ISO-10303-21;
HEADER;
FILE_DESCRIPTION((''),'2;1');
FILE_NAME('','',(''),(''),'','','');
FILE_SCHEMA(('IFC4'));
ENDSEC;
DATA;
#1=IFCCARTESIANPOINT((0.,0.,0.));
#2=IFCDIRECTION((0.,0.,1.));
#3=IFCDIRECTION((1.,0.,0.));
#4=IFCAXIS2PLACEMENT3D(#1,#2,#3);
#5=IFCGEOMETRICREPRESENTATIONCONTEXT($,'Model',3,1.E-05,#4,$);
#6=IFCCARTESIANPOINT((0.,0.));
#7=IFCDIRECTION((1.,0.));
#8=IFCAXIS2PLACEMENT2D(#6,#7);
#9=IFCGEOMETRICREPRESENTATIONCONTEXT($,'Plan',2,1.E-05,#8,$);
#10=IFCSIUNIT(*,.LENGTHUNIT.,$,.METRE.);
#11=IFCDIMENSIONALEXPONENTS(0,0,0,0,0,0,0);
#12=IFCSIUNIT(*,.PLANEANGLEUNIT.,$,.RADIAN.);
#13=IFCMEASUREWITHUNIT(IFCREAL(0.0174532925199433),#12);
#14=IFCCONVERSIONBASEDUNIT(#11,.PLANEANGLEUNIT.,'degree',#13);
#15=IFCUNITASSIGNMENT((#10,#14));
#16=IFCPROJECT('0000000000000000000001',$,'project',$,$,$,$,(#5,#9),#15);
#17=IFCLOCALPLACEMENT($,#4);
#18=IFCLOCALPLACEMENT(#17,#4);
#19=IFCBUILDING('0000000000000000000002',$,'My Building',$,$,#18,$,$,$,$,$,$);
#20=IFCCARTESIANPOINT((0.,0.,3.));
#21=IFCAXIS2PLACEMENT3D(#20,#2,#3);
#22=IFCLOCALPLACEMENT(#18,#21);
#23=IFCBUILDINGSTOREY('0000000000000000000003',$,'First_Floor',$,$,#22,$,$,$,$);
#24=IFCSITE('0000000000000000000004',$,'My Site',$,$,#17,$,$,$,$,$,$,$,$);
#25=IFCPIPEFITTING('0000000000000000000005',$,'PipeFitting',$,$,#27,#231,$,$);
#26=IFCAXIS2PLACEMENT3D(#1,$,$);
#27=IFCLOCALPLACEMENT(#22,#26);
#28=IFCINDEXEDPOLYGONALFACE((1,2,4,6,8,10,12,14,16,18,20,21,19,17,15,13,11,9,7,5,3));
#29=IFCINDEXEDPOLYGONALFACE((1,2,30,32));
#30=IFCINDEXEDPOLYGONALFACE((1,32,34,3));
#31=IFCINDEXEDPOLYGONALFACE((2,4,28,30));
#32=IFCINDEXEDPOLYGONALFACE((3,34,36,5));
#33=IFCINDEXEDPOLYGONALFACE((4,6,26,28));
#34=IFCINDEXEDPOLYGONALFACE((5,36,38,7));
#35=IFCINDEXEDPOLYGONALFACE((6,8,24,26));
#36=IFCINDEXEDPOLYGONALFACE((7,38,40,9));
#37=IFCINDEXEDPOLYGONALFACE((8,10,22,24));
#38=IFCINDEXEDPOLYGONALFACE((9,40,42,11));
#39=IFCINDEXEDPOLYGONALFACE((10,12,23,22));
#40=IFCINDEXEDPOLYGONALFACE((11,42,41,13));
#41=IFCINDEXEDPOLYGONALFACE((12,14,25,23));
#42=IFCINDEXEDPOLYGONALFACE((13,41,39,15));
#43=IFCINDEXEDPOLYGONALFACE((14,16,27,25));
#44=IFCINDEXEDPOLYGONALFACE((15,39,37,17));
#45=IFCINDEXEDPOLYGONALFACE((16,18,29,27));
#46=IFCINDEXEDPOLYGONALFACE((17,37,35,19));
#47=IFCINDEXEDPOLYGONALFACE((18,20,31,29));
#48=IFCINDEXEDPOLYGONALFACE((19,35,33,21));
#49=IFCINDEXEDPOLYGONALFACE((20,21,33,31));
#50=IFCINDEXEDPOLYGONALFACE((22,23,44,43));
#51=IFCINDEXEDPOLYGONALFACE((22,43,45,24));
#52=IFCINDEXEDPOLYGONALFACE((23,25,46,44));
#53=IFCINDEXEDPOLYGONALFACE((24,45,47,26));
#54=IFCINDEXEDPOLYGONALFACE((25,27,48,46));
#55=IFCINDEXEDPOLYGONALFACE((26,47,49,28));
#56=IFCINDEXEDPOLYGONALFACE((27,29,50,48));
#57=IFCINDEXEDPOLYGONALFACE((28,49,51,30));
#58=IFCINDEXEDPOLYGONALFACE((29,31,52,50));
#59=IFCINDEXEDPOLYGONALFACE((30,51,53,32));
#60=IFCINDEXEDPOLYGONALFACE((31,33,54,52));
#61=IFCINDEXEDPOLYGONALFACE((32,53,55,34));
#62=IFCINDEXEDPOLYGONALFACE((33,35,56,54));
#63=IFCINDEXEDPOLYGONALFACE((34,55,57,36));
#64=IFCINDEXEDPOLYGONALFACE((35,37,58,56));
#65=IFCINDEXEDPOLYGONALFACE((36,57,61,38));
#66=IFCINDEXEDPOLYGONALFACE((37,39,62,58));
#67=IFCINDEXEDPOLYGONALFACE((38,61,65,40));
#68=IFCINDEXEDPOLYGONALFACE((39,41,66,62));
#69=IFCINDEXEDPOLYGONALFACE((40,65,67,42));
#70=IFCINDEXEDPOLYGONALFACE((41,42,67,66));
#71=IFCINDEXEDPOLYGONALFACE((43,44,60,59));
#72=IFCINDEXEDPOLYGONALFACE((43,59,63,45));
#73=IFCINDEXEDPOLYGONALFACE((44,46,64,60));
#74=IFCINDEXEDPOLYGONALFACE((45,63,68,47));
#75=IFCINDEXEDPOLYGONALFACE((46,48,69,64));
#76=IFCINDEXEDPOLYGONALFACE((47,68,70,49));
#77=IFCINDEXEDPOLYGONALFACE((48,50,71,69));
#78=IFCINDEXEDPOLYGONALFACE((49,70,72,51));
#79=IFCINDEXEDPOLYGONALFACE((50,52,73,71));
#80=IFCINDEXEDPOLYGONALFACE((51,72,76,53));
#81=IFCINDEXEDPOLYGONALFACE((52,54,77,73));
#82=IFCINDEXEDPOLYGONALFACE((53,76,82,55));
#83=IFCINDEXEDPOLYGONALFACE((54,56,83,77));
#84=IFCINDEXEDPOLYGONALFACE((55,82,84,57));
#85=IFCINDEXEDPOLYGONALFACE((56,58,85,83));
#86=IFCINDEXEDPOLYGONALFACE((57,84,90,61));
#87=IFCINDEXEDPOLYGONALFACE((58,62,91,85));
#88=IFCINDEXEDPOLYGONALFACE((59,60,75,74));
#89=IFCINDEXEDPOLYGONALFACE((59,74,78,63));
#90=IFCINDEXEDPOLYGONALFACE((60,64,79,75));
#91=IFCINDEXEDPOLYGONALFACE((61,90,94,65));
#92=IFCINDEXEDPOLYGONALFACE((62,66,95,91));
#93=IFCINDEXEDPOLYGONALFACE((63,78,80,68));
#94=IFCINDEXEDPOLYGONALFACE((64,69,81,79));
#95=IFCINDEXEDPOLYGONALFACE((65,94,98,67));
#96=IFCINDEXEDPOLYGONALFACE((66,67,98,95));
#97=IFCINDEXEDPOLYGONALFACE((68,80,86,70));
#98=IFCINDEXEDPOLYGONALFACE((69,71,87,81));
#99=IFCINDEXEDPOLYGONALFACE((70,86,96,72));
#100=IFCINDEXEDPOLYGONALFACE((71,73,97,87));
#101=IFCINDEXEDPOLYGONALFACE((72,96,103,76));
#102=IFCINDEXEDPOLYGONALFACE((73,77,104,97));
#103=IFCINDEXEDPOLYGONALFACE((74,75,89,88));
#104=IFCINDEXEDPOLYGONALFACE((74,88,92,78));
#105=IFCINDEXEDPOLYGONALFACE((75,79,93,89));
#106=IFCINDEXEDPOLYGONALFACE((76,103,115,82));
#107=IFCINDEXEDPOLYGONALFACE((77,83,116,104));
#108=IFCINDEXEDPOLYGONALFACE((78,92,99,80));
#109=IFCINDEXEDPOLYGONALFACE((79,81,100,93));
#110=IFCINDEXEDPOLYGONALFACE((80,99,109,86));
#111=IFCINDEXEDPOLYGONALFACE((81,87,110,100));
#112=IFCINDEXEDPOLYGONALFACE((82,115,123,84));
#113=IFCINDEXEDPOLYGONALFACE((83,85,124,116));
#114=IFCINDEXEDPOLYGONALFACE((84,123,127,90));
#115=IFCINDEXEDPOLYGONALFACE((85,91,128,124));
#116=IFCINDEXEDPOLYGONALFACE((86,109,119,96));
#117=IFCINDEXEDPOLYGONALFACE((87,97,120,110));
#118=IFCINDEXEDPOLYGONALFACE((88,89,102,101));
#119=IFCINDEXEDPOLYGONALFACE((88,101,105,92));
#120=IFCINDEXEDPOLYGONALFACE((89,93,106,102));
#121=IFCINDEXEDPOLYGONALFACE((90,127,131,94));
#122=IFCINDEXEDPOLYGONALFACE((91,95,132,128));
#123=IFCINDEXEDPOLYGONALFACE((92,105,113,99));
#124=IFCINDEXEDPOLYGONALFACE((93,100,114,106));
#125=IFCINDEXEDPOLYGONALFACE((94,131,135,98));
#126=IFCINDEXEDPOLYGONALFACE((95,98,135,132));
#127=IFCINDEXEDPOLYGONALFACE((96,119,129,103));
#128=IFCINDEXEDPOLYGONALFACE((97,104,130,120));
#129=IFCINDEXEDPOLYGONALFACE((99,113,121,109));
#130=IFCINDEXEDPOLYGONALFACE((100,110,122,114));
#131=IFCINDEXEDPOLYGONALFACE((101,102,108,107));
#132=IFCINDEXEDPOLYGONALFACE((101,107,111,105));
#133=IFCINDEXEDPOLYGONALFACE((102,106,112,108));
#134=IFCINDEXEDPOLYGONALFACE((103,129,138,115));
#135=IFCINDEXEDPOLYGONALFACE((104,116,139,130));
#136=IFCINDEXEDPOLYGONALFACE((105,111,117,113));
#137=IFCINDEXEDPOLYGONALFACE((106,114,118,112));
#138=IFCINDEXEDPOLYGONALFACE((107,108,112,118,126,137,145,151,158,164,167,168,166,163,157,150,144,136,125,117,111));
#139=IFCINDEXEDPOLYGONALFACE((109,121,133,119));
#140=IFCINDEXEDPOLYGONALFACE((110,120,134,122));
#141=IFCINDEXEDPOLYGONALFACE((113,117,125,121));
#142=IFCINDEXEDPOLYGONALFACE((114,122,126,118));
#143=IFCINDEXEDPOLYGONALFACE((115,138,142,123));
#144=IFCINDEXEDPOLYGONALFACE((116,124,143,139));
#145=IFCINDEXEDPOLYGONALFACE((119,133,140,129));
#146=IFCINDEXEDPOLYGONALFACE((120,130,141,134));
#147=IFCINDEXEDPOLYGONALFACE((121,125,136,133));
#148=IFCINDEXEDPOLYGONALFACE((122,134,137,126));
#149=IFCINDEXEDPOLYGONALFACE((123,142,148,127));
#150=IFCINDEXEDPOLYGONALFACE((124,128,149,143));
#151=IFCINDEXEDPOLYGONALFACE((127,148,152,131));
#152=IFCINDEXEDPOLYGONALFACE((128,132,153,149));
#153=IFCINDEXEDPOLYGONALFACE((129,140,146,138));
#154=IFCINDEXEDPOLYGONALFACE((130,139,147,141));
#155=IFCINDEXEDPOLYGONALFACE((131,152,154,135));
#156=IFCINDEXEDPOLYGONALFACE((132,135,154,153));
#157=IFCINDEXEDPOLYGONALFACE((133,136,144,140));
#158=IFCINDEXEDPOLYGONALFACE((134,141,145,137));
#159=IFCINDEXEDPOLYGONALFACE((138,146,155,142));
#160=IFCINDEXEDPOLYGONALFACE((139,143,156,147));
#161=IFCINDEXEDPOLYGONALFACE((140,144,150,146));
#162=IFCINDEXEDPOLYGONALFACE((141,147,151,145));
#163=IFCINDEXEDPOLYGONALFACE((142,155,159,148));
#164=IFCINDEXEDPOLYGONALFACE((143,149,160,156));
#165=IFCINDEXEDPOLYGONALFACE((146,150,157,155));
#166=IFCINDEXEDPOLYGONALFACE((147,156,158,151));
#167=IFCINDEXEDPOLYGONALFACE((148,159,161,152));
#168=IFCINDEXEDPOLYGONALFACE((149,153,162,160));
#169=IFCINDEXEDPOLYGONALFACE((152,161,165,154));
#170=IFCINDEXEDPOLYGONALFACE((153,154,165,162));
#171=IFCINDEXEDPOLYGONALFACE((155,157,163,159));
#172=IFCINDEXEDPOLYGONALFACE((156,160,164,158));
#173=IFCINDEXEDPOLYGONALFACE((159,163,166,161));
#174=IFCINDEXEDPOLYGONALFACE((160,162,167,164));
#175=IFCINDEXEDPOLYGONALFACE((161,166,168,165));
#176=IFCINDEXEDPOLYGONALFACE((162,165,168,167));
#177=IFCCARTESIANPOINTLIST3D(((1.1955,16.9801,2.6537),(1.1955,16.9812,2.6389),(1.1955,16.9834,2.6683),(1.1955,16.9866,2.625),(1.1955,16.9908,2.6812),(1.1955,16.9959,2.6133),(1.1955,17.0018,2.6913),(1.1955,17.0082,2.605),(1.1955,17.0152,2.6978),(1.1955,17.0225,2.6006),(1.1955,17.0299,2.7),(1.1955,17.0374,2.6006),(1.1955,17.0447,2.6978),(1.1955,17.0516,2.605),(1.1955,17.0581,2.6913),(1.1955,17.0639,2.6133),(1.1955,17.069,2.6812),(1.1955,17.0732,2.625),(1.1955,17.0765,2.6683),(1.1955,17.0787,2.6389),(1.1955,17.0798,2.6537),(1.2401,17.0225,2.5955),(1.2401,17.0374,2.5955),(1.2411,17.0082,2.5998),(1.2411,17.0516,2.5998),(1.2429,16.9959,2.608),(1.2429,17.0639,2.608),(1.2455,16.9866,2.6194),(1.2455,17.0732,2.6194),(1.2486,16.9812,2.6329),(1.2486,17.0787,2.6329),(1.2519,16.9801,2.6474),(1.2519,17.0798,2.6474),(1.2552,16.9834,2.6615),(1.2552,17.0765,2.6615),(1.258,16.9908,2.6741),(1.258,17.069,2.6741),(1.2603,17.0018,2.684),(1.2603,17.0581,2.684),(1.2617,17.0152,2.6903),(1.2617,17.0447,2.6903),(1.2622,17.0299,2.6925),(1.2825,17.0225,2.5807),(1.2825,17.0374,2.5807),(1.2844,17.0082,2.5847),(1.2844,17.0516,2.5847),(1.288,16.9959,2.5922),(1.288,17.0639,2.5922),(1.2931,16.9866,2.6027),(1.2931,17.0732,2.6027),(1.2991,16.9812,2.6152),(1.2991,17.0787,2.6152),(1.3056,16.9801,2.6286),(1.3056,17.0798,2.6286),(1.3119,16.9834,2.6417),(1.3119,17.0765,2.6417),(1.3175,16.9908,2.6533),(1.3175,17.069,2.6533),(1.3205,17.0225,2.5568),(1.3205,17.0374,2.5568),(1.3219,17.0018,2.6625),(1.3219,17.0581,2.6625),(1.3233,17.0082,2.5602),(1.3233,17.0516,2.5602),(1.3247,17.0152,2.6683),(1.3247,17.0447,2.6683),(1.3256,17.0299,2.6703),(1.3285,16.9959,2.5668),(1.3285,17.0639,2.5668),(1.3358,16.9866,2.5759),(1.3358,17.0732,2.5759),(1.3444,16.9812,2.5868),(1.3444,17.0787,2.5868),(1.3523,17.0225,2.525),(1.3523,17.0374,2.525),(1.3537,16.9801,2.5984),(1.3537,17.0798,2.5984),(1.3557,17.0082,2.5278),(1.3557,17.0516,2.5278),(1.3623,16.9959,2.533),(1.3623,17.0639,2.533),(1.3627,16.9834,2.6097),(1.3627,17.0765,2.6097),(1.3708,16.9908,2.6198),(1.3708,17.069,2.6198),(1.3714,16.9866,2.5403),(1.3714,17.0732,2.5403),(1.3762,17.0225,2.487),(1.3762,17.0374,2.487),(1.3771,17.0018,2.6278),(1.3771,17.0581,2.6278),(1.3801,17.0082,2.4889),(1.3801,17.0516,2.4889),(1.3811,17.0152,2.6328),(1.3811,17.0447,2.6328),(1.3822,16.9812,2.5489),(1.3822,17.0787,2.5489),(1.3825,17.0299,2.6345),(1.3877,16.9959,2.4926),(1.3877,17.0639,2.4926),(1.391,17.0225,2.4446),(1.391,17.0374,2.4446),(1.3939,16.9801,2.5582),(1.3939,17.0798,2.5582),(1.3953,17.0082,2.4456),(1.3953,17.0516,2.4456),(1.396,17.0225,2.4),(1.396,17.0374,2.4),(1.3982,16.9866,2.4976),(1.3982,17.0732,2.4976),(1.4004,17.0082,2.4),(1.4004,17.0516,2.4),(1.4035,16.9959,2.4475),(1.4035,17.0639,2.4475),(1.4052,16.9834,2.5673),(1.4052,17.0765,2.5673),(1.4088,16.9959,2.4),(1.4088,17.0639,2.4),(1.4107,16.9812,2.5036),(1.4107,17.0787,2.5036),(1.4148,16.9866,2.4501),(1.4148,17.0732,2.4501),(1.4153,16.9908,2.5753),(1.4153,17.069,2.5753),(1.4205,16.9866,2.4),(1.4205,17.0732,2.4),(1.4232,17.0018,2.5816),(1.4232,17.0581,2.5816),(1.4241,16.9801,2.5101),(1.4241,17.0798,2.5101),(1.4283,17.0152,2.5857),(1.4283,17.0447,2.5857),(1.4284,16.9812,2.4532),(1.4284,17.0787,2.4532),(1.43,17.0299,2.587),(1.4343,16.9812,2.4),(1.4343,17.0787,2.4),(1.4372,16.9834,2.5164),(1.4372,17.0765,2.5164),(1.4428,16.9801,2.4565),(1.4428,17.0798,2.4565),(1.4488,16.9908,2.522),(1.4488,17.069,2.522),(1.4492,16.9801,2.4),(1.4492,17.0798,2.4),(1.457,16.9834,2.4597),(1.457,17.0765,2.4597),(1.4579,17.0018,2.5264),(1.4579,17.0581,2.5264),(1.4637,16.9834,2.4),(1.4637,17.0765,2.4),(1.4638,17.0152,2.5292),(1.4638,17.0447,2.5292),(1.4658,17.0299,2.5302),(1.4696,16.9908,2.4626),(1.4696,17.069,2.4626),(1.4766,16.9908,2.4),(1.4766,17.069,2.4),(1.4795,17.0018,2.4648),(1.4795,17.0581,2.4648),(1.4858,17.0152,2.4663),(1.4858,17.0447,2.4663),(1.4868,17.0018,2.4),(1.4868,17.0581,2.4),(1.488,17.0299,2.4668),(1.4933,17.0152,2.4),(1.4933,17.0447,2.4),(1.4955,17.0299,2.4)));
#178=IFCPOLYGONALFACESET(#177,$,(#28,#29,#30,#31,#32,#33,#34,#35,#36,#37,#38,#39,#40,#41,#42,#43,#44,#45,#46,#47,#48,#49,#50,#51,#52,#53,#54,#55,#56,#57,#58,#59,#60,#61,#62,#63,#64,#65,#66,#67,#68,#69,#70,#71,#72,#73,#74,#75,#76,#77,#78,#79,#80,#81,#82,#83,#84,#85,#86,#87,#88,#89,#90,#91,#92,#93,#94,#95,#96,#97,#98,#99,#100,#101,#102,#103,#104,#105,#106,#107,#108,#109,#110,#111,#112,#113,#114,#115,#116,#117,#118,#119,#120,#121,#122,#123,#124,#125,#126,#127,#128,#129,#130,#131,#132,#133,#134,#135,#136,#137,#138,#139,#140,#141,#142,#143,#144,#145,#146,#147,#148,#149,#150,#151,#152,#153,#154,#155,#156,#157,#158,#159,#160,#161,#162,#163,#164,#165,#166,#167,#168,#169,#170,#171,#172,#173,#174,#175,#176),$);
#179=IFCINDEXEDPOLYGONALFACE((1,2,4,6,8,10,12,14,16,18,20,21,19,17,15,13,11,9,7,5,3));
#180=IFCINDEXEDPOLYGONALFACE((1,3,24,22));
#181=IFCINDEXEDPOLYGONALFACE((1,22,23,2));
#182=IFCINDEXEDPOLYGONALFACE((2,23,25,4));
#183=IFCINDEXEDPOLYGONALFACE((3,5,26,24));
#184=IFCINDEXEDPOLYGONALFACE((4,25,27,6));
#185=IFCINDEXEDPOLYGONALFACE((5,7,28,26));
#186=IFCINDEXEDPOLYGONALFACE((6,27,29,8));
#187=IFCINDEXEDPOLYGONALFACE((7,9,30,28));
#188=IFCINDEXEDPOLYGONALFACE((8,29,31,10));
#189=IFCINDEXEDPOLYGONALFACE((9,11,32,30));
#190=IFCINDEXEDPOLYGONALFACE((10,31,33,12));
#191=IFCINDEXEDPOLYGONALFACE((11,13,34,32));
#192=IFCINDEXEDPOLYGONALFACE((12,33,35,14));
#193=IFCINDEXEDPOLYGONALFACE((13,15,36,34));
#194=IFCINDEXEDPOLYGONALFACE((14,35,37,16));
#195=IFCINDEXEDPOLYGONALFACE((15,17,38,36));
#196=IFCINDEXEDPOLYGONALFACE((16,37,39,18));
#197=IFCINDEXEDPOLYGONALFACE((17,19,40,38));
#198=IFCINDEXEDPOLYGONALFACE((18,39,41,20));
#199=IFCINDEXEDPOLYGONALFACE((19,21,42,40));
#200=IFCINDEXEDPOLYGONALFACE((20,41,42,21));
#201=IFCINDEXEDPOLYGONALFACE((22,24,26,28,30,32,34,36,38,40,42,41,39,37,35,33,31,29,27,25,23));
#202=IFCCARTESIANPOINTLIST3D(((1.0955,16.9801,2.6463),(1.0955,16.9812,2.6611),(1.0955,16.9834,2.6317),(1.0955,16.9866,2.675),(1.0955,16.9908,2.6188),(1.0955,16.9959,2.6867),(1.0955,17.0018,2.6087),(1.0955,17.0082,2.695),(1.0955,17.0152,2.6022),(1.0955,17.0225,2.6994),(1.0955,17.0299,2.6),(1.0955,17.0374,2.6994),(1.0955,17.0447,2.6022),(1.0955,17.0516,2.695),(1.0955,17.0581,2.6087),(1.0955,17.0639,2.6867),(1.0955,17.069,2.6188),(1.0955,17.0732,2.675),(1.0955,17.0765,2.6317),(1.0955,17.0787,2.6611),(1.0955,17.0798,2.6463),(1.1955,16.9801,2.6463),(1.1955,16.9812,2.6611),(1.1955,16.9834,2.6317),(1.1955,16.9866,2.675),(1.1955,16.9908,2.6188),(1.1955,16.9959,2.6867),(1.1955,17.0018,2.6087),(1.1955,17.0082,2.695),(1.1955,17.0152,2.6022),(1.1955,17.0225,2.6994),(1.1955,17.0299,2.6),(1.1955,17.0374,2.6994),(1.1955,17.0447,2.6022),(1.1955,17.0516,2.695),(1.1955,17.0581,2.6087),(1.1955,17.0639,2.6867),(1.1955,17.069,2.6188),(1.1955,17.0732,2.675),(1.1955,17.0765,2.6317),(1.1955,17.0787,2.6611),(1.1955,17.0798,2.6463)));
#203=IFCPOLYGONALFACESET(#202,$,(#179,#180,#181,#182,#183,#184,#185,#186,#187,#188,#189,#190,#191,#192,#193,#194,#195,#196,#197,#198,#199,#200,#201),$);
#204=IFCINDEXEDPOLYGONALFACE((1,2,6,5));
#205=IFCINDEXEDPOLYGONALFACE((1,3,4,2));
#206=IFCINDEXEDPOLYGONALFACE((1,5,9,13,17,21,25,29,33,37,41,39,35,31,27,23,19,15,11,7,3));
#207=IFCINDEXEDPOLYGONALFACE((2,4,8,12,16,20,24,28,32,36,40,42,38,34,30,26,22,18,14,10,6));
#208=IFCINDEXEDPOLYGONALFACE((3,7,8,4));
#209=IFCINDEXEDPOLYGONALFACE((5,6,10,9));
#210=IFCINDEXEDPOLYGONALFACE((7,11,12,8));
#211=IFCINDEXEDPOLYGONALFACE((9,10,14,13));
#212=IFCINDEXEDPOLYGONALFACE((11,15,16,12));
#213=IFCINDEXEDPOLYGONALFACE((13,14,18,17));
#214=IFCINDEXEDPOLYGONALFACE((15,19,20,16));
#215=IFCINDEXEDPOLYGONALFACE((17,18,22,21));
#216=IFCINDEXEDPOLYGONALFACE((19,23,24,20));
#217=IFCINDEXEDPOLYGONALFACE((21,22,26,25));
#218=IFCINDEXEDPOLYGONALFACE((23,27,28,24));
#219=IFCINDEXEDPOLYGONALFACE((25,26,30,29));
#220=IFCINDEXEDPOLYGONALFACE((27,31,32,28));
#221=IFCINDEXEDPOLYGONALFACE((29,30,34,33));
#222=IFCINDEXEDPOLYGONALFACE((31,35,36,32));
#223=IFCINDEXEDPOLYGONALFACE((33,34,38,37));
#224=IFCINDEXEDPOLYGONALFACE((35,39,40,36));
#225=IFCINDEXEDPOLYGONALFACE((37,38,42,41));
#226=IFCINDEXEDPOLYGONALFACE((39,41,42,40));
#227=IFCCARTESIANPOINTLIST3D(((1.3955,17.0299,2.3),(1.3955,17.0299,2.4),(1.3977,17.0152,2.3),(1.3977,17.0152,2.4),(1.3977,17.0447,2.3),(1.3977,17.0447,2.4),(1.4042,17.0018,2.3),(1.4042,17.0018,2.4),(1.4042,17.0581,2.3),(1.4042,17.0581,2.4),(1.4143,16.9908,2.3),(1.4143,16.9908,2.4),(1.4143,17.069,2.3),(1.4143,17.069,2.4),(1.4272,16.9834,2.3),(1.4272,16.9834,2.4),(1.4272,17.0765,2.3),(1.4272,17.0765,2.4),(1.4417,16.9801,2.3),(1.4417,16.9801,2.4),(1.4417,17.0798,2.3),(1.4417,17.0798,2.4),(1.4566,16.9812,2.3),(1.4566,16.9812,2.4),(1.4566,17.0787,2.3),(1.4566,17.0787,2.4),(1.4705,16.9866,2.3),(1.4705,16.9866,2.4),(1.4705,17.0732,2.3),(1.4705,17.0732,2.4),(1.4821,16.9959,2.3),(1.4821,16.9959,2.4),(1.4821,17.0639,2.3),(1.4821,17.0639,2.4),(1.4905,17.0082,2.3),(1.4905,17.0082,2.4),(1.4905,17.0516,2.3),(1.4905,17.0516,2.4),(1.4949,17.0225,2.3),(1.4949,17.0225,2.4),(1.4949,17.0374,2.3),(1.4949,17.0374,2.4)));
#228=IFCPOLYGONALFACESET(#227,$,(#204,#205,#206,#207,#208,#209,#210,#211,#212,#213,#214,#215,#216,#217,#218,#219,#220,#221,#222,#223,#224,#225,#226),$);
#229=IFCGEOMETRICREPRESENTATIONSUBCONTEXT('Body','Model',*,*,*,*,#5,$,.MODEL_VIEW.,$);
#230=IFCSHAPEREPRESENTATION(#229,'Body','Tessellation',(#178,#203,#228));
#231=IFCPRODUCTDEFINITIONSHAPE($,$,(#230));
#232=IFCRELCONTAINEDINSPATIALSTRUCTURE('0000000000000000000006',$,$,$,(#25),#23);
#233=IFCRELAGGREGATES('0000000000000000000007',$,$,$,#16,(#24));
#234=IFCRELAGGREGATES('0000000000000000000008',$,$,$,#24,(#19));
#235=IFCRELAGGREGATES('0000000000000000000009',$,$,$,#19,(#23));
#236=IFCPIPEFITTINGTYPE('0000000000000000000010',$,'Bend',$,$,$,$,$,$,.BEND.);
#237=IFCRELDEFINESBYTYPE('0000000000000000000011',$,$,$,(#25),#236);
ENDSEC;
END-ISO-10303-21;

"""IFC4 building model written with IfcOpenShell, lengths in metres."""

from ifc_helpers import new_model, entity, si_unit, converted_unit, frame, origin_with_axes, origin_2d_with_axis, place, context, subcontext, project, spatial, circle, extrude, source, transform, mapped, type_object, type_shapes, element, save


model = new_model("IFC4")

# Units and contexts
model_context = context("Model", 3, precision=1e-05, world=origin_with_axes())
plan_context = context("Plan", 2, precision=1e-05, world=origin_2d_with_axis())
body_context = subcontext(model_context, "Body", "Model", "MODEL_VIEW")
ifc_project = project(units=[si_unit("LENGTHUNIT", "METRE"), converted_unit("PLANEANGLEUNIT", "degree", entity("IfcReal", 0.0174532925199433), si_unit("PLANEANGLEUNIT", "RADIAN"), dimensions=[0, 0, 0, 0, 0, 0, 0])], contexts=[model_context, plan_context])

# Site, building, storey
site_placement = place(None, origin_with_axes())
site = spatial("IfcSite", under=ifc_project, at=site_placement, Name="My Site")
building_placement = place(site_placement, origin_with_axes())
building = spatial("IfcBuilding", under=site, at=building_placement, Name="My Building")
storey_placement = place(building_placement, frame((0.0, 0.0, 3.0), z_axis=(0.0, 0.0, 1.0), x_axis=(1.0, 0.0, 0.0)))
storey = spatial("IfcBuildingStorey", under=building, at=storey_placement, Name="First_Floor")

# Pipe fitting
pipe_fitting_type = type_object("IfcPipeFittingType", Name="Bend", PredefinedType="BEND")
shared_shape = source(origin_with_axes(), body_context, "Body", "SolidModel", [
    entity("IfcSweptDiskSolid", entity("IfcIndexedPolyCurve", entity("IfcCartesianPointList3D", [[0.0, 0.0, -0.1], [0.0732, 0.0, -0.2768], [0.25, 0.0, -0.35]]), [entity("IfcArcIndex", [1, 2, 3])]), 0.05),
    extrude(circle(Radius=0.05), origin_with_axes(), (0.0, 0.0, -1.0), 0.1),
    extrude(circle(Radius=0.05), frame((0.25, 0.0, -0.35), z_axis=(1.0, 0.0, 0.0), x_axis=(0.0, 0.0, 1.0)), (0.0, 0.0, 1.0), 0.1),
])
type_shapes(pipe_fitting_type, [shared_shape])
for number, where, z_axis, x_axis, name in (
    (1, (1.0955, 17.0299, 2.65), (-1.0, 0.0, 0.0), (0.0, 0.0, -1.0), "PipeFitting"),
):
    element("IfcPipeFitting", number, at=place(storey_placement, frame(where, z_axis=z_axis, x_axis=x_axis)), inside=storey, type_object=pipe_fitting_type, Name=name, context=body_context, shape_type="MappedRepresentation", body=[
        mapped(shared_shape, transform((0.0, 0.0, 0.0), x_axis=(1.0, 0.0, 0.0), y_axis=(0.0, 1.0, 0.0), z_axis=(0.0, 0.0, 1.0), scale=1.0)),
    ])

save(model, "model.ifc")
